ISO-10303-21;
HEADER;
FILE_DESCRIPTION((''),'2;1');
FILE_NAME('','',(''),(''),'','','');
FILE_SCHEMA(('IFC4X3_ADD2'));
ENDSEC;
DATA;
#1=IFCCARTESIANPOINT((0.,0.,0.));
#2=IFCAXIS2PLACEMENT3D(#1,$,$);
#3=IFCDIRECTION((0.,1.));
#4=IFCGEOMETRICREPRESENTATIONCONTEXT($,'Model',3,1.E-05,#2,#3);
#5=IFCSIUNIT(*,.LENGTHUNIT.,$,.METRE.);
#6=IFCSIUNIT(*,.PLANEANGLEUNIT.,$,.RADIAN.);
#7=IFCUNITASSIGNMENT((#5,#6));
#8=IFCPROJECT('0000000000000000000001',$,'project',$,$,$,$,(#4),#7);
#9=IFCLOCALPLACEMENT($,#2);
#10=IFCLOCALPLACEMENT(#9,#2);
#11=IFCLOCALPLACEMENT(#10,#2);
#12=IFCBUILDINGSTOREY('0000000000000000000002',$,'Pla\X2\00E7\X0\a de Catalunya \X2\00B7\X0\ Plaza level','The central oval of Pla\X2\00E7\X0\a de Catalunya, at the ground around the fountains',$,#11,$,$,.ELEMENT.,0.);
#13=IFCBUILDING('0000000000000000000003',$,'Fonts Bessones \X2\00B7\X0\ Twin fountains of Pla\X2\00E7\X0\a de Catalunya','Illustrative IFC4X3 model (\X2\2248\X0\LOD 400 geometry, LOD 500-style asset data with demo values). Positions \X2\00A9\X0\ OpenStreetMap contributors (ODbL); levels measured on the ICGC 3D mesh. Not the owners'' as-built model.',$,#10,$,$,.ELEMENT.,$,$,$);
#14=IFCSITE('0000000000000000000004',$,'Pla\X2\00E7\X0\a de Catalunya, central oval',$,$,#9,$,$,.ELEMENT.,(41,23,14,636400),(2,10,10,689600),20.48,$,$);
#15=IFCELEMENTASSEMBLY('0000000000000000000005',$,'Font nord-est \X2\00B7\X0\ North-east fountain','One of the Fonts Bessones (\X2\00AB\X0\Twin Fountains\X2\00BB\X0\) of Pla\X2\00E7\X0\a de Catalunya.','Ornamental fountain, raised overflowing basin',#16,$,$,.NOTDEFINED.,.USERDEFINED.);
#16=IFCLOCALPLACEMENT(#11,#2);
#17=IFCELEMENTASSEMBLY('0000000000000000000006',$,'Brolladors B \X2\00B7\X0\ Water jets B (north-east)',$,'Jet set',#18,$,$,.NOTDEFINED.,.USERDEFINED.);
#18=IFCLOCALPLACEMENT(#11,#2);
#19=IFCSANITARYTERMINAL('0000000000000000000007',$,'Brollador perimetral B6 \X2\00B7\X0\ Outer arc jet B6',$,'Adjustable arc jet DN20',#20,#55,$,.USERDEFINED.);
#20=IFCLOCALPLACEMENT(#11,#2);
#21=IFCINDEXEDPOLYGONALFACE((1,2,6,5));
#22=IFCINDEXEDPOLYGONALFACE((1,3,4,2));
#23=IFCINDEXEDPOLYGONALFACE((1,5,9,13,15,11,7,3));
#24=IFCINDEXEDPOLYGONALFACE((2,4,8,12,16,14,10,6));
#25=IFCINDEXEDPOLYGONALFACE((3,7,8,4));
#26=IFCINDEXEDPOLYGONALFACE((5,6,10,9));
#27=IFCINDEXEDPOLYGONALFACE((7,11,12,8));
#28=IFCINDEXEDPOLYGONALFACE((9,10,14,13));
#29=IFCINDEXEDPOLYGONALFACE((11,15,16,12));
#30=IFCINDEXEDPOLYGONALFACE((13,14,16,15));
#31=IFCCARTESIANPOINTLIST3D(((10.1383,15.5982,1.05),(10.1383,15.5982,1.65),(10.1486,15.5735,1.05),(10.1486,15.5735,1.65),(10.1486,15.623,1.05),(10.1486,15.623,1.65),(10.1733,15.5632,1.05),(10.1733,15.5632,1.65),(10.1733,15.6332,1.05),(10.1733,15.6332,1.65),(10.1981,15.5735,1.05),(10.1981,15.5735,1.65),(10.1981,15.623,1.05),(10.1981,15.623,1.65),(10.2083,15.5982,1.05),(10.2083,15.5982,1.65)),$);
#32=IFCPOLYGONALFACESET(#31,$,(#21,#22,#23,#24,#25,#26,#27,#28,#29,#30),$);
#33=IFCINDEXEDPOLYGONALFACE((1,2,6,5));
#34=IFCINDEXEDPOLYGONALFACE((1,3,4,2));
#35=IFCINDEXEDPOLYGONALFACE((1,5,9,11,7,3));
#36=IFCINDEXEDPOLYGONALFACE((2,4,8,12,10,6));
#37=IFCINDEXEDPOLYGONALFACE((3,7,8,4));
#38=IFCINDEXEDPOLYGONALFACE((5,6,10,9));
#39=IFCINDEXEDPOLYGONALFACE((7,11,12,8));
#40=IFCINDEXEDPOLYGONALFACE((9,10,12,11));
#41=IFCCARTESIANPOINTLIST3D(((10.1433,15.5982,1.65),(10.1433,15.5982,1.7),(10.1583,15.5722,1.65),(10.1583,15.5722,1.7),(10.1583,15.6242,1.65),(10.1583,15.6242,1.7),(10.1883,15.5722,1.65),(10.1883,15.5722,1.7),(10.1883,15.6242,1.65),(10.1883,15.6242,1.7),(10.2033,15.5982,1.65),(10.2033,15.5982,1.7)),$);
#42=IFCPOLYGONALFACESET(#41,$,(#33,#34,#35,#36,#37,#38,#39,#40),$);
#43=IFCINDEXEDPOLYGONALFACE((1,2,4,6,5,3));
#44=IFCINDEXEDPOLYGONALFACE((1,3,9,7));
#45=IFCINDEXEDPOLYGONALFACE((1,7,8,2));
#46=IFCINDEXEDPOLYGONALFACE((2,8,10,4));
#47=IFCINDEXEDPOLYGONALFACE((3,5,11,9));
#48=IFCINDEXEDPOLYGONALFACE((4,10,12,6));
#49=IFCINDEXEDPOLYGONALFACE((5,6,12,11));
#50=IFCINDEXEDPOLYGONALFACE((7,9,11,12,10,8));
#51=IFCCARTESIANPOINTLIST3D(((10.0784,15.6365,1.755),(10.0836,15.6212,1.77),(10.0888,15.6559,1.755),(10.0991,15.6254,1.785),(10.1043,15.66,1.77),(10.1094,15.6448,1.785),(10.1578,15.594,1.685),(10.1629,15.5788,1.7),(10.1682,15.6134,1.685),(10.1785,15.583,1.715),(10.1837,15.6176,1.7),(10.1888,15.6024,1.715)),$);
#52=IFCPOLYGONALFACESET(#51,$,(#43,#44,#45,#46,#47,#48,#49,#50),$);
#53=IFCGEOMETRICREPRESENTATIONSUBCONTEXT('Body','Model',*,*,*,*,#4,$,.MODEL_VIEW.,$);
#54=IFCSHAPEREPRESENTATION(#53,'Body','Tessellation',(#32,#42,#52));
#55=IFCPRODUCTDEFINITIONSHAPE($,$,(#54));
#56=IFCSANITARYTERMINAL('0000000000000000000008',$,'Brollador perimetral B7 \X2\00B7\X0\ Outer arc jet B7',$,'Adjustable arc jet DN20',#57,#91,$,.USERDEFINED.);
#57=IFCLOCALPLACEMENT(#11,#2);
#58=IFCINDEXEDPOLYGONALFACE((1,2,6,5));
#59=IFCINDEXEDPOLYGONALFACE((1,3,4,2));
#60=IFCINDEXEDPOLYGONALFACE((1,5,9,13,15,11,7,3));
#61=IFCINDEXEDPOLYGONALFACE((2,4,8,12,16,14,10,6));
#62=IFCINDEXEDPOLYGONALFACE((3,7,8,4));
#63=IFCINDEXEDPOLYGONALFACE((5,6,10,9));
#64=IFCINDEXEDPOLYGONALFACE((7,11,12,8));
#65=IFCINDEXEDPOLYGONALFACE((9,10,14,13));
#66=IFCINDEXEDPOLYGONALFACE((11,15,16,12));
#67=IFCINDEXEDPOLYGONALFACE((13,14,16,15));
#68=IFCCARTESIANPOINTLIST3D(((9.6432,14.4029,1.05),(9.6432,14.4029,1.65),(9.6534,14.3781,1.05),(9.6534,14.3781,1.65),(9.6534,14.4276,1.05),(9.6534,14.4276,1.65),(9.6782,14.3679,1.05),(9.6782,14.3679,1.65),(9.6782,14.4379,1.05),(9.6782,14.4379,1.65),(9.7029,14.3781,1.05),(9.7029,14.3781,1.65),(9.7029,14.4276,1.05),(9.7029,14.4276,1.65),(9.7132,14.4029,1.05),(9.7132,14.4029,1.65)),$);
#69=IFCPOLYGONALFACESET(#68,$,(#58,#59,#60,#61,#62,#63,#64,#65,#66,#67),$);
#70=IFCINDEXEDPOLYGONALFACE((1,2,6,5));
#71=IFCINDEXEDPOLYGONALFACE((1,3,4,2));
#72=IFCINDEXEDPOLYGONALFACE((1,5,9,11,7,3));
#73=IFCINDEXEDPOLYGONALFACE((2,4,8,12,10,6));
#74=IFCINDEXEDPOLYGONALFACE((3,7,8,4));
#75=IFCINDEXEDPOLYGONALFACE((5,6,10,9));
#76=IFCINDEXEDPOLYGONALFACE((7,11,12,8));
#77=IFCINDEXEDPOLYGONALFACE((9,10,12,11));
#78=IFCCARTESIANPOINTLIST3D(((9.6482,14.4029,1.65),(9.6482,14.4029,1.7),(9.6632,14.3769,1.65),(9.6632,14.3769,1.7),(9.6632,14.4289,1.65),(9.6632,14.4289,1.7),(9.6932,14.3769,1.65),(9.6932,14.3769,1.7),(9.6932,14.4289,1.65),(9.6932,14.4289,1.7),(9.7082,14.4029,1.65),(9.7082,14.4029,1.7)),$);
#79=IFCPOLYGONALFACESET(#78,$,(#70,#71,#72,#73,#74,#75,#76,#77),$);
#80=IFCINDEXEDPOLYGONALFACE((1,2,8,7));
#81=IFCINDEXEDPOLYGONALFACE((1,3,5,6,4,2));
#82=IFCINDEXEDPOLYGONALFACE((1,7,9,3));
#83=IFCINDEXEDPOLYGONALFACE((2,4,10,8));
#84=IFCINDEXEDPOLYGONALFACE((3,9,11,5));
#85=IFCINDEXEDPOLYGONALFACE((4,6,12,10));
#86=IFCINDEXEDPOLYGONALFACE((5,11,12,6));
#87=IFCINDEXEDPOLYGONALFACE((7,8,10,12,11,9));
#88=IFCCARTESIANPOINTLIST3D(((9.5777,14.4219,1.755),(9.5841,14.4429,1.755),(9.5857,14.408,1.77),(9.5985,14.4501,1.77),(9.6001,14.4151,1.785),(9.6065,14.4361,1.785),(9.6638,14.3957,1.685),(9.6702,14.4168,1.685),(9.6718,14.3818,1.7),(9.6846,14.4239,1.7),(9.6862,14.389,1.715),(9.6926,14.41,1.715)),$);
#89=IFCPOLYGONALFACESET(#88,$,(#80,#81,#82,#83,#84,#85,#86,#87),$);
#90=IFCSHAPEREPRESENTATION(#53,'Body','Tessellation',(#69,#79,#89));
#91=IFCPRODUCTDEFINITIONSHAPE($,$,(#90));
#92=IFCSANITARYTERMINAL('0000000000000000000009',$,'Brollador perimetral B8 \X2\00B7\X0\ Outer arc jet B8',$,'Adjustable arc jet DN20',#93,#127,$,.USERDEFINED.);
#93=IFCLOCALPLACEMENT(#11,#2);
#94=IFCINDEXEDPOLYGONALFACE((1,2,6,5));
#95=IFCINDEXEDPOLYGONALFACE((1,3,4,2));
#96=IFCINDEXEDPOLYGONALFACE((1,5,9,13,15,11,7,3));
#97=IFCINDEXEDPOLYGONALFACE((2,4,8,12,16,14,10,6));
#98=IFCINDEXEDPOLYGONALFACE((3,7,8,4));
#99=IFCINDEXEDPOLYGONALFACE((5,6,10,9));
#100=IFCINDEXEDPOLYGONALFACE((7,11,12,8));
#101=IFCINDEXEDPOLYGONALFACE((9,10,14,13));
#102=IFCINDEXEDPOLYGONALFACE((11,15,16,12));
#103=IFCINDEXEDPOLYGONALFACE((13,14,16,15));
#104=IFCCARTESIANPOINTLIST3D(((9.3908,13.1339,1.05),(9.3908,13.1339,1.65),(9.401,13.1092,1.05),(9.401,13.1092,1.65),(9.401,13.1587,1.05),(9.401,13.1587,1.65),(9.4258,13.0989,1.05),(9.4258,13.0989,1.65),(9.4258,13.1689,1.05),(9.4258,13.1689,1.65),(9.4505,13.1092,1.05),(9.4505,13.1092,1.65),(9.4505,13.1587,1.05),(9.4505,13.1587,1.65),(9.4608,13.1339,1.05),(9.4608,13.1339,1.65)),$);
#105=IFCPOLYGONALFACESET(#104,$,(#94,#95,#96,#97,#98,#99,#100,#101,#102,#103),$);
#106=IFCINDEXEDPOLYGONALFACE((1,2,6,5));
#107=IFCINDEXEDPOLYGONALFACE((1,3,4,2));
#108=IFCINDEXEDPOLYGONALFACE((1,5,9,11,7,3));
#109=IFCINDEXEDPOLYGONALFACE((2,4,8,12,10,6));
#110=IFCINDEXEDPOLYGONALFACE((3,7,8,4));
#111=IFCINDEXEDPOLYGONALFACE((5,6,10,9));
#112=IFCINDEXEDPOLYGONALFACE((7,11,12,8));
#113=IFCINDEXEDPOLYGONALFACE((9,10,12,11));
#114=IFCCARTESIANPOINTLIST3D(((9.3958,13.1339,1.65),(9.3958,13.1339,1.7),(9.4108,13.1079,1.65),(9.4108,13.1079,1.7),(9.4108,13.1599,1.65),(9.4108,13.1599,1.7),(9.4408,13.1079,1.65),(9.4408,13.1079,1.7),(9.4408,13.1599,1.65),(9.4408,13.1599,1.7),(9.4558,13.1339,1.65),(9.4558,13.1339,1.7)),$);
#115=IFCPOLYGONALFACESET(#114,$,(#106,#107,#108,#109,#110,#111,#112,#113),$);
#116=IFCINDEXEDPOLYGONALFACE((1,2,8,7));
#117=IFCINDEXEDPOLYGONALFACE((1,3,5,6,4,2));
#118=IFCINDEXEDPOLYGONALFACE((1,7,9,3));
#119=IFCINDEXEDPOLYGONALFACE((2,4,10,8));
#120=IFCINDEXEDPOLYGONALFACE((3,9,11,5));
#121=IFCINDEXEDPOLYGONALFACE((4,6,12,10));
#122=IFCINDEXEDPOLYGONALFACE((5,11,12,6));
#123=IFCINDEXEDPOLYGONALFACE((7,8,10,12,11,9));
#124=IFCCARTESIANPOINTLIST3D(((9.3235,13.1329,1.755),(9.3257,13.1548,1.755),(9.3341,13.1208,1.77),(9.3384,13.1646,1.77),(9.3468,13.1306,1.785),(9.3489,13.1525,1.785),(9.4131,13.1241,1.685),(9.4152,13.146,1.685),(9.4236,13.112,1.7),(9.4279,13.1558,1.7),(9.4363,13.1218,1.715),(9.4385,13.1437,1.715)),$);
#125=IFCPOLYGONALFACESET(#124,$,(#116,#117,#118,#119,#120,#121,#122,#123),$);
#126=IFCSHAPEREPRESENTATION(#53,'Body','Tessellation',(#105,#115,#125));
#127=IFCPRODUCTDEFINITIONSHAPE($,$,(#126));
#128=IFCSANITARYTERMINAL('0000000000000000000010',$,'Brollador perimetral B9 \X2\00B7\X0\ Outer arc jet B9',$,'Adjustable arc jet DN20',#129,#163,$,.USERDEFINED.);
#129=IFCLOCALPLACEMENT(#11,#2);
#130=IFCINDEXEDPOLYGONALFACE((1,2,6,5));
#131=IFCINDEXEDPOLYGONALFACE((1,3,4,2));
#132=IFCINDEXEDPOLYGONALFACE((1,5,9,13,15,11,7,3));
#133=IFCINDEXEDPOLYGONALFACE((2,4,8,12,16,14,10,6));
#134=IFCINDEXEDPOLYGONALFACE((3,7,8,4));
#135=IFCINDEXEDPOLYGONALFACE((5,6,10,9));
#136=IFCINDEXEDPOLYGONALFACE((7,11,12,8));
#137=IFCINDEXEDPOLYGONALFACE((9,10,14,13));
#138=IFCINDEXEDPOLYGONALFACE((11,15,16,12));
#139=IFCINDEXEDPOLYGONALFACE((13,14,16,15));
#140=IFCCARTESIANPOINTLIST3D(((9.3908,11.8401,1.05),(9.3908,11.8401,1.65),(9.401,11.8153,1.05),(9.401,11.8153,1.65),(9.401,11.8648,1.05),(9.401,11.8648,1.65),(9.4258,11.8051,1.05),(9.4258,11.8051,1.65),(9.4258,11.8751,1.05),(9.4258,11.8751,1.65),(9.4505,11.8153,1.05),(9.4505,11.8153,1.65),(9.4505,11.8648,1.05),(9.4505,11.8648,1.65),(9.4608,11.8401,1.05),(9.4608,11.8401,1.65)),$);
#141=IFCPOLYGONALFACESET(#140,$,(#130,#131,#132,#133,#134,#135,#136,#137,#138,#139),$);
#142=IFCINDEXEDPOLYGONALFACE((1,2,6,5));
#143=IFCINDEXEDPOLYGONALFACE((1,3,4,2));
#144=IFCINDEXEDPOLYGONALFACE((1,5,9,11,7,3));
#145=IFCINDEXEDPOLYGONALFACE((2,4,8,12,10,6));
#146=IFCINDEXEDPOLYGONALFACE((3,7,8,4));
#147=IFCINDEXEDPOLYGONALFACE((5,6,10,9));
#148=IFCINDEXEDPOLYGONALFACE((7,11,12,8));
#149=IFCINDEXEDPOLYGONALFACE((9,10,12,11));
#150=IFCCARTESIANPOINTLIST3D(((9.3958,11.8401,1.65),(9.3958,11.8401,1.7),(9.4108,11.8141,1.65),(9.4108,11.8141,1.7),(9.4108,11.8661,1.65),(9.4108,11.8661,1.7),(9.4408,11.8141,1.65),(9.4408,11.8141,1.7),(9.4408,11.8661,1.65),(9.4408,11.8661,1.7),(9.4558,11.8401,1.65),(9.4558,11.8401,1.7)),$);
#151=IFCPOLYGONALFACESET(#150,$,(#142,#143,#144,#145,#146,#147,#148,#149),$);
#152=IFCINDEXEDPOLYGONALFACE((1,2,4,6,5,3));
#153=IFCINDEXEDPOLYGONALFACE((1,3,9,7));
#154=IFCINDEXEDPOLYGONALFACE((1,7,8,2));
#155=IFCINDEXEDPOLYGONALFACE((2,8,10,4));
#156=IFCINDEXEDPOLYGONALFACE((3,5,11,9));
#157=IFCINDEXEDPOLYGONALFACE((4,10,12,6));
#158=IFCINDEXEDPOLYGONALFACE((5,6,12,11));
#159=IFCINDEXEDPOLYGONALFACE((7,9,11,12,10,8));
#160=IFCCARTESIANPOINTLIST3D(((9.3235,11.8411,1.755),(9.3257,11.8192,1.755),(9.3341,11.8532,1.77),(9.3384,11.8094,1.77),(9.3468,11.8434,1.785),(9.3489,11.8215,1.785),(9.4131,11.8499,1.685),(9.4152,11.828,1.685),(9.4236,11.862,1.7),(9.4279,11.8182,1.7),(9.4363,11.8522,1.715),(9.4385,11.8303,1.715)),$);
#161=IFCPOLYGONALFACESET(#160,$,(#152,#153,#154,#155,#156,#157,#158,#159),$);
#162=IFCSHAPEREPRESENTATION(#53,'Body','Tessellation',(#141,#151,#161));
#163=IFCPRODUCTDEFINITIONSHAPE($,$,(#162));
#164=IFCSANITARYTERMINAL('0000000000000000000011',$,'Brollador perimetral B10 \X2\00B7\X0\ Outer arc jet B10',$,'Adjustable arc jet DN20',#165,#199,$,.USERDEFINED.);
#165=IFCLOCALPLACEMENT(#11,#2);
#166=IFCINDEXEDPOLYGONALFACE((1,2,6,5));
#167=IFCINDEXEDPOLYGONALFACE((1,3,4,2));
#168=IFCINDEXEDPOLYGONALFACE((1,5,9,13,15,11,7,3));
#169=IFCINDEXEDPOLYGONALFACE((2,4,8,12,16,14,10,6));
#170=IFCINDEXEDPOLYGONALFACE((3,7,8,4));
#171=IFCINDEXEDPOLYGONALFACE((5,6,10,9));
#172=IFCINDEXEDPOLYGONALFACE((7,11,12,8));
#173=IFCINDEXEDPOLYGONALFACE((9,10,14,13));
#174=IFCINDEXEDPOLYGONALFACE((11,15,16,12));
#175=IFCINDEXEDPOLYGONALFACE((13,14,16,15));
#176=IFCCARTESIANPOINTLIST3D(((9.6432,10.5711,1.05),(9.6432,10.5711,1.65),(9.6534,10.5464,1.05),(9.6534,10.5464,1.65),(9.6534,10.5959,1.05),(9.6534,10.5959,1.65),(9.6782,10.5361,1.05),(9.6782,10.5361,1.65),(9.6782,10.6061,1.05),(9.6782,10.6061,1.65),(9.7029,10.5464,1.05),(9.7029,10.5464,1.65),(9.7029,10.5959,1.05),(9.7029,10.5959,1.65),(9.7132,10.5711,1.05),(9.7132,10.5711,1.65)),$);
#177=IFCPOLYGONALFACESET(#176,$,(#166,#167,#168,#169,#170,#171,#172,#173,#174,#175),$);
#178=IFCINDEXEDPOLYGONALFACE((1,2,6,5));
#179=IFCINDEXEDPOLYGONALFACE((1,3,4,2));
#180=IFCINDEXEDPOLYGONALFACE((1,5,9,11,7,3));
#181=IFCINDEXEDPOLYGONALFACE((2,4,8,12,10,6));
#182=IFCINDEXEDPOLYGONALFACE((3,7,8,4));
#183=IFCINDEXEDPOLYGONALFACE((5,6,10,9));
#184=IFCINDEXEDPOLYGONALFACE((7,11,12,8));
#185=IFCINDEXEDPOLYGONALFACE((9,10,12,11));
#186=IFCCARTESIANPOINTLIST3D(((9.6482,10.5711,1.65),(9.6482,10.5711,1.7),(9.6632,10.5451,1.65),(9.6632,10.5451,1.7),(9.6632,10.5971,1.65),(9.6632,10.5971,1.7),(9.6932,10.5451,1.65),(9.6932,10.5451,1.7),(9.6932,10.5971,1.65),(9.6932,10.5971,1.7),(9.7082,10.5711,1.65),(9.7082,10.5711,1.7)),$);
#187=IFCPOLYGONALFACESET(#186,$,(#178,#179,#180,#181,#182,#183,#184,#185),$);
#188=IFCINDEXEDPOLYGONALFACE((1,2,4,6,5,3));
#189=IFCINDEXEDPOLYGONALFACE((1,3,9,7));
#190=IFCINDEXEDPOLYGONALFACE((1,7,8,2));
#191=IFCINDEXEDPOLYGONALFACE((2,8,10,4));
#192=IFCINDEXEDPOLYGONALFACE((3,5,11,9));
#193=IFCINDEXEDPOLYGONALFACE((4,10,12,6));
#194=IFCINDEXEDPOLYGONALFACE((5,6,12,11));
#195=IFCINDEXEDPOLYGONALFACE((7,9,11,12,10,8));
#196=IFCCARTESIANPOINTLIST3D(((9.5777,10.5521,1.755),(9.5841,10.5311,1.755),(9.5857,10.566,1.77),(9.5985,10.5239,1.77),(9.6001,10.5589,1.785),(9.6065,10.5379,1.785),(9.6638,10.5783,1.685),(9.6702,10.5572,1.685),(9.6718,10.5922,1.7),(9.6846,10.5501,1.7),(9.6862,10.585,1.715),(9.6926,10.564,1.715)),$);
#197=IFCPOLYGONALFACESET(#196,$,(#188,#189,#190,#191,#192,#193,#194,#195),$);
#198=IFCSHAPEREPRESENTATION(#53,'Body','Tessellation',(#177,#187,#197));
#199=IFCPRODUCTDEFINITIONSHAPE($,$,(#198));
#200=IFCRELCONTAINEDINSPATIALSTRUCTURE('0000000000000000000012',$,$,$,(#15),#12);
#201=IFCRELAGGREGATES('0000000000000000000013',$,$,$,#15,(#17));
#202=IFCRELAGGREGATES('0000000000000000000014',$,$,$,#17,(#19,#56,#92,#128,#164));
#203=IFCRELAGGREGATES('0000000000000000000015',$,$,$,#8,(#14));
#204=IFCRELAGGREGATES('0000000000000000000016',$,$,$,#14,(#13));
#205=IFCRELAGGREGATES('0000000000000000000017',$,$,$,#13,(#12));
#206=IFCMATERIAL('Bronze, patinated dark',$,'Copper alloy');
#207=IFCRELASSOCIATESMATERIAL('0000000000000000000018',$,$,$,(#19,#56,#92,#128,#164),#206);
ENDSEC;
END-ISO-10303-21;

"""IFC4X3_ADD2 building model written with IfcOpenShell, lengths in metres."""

from ifc_helpers import new_model, si_unit, direction, frame, origin, place, context, subcontext, project, spatial, polyline, outline, extrude, material, element, aggregate, save


model = new_model("IFC4X3_ADD2")

# Units and contexts
model_context = context("Model", 3, precision=1e-05, world=origin(), true_north=direction((0.0, 1.0)))
body_context = subcontext(model_context, "Body", "Model", "MODEL_VIEW")
ifc_project = project(units=[si_unit("LENGTHUNIT", "METRE"), si_unit("PLANEANGLEUNIT", "RADIAN")], contexts=[model_context])

# Site, building, storey
site_placement = place(None, origin())
site = spatial("IfcSite", under=ifc_project, at=site_placement, Name="Plaça de Catalunya, central oval", CompositionType="ELEMENT", RefLatitude=(41, 23, 14, 636400), RefLongitude=(2, 10, 10, 689600), RefElevation=20.48)
building_placement = place(site_placement, origin())
building = spatial("IfcBuilding", under=site, at=building_placement, Name="Fonts Bessones · Twin fountains of Plaça de Catalunya", Description="Illustrative IFC4X3 model (≈LOD 400 geometry, LOD 500-style asset data with demo values). Positions © OpenStreetMap contributors (ODbL); levels measured on the ICGC 3D mesh. Not the owners' as-built model.", CompositionType="ELEMENT")
storey_placement = place(building_placement, origin())
storey = spatial("IfcBuildingStorey", under=building, at=storey_placement, Name="Plaça de Catalunya · Plaza level", Description="The central oval of Plaça de Catalunya, at the ground around the fountains", CompositionType="ELEMENT", Elevation=0.0)

# Element assemblies, sanitary terminals
assembly_1_placement = place(building_placement, origin())
assembly_1 = element("IfcElementAssembly", 1, at=assembly_1_placement, inside=storey, Name="Font nord-est · North-east fountain", Description="One of the Fonts Bessones («Twin Fountains») of Plaça de Catalunya.", ObjectType="Ornamental fountain, raised overflowing basin", AssemblyPlace="NOTDEFINED", PredefinedType="USERDEFINED")
assembly_2_placement = place(building_placement, origin())
assembly_2 = element("IfcElementAssembly", 2, at=assembly_2_placement, Name="Brolladors B · Water jets B (north-east)", ObjectType="Jet set", AssemblyPlace="NOTDEFINED", PredefinedType="USERDEFINED")
aggregate(assembly_1, [assembly_2])
ifc_material_1 = material(Name="Bronze, patinated dark", Category="Copper alloy")
sanitary_terminal_1_placement = place(building_placement, origin())
sanitary_terminal_1 = element("IfcSanitaryTerminal", 3, at=sanitary_terminal_1_placement, material=ifc_material_1, Name="Brollador perimetral B6 · Outer arc jet B6", ObjectType="Adjustable arc jet DN20", PredefinedType="USERDEFINED", context=body_context, shape_type="SweptSolid", body=[
    extrude(outline(polyline([(10.2083, 15.5982), (10.1981, 15.623), (10.1733, 15.6332), (10.1486, 15.623), (10.1383, 15.5982), (10.1486, 15.5735), (10.1733, 15.5632), (10.1981, 15.5735), (10.2083, 15.5982)])), frame((0.0, 0.0, 1.05)), (0.0, 0.0, 1.0), 0.6),
    extrude(outline(polyline([(10.2033, 15.5982), (10.1883, 15.6242), (10.1583, 15.6242), (10.1433, 15.5982), (10.1583, 15.5722), (10.1883, 15.5722), (10.2033, 15.5982)])), frame((0.0, 0.0, 1.65)), (0.0, 0.0, 1.0), 0.05),
    extrude(outline(polyline([(0.022, 0.0), (0.011, 0.0191), (-0.011, 0.0191), (-0.022, 0.0), (-0.011, -0.0191), (0.011, -0.0191), (0.022, 0.0)])), frame((10.1733, 15.5982, 1.7), z_axis=(-0.696147, 0.372098, 0.613941), x_axis=(0.471397, 0.881921, 0.0)), (0.0, 0.0, 1.0), 0.114),
])
sanitary_terminal_2_placement = place(building_placement, origin())
sanitary_terminal_2 = element("IfcSanitaryTerminal", 4, at=sanitary_terminal_2_placement, material=ifc_material_1, Name="Brollador perimetral B7 · Outer arc jet B7", ObjectType="Adjustable arc jet DN20", PredefinedType="USERDEFINED", context=body_context, shape_type="SweptSolid", body=[
    extrude(outline(polyline([(9.7132, 14.4029), (9.7029, 14.4276), (9.6782, 14.4379), (9.6534, 14.4276), (9.6432, 14.4029), (9.6534, 14.3781), (9.6782, 14.3679), (9.7029, 14.3781), (9.7132, 14.4029)])), frame((0.0, 0.0, 1.05)), (0.0, 0.0, 1.0), 0.6),
    extrude(outline(polyline([(9.7082, 14.4029), (9.6932, 14.4289), (9.6632, 14.4289), (9.6482, 14.4029), (9.6632, 14.3769), (9.6932, 14.3769), (9.7082, 14.4029)])), frame((0.0, 0.0, 1.65)), (0.0, 0.0, 1.0), 0.05),
    extrude(outline(polyline([(0.022, 0.0), (0.011, 0.0191), (-0.011, 0.0191), (-0.022, 0.0), (-0.011, -0.0191), (0.011, -0.0191), (0.022, 0.0)])), frame((9.6782, 14.4029, 1.7), z_axis=(-0.755363, 0.229137, 0.613941), x_axis=(0.290285, 0.95694, 0.0)), (0.0, 0.0, 1.0), 0.114),
])
sanitary_terminal_3_placement = place(building_placement, origin())
sanitary_terminal_3 = element("IfcSanitaryTerminal", 5, at=sanitary_terminal_3_placement, material=ifc_material_1, Name="Brollador perimetral B8 · Outer arc jet B8", ObjectType="Adjustable arc jet DN20", PredefinedType="USERDEFINED", context=body_context, shape_type="SweptSolid", body=[
    extrude(outline(polyline([(9.4608, 13.1339), (9.4505, 13.1587), (9.4258, 13.1689), (9.401, 13.1587), (9.3908, 13.1339), (9.401, 13.1092), (9.4258, 13.0989), (9.4505, 13.1092), (9.4608, 13.1339)])), frame((0.0, 0.0, 1.05)), (0.0, 0.0, 1.0), 0.6),
    extrude(outline(polyline([(9.4558, 13.1339), (9.4408, 13.1599), (9.4108, 13.1599), (9.3958, 13.1339), (9.4108, 13.1079), (9.4408, 13.1079), (9.4558, 13.1339)])), frame((0.0, 0.0, 1.65)), (0.0, 0.0, 1.0), 0.05),
    extrude(outline(polyline([(0.022, 0.0), (0.011, 0.0191), (-0.011, 0.0191), (-0.022, 0.0), (-0.011, -0.0191), (0.011, -0.0191), (0.022, 0.0)])), frame((9.4258, 13.1339, 1.7), z_axis=(-0.785551, 0.07737, 0.613941), x_axis=(0.098017, 0.995185, 0.0)), (0.0, 0.0, 1.0), 0.114),
])
sanitary_terminal_4_placement = place(building_placement, origin())
sanitary_terminal_4 = element("IfcSanitaryTerminal", 6, at=sanitary_terminal_4_placement, material=ifc_material_1, Name="Brollador perimetral B9 · Outer arc jet B9", ObjectType="Adjustable arc jet DN20", PredefinedType="USERDEFINED", context=body_context, shape_type="SweptSolid", body=[
    extrude(outline(polyline([(9.4608, 11.8401), (9.4505, 11.8648), (9.4258, 11.8751), (9.401, 11.8648), (9.3908, 11.8401), (9.401, 11.8153), (9.4258, 11.8051), (9.4505, 11.8153), (9.4608, 11.8401)])), frame((0.0, 0.0, 1.05)), (0.0, 0.0, 1.0), 0.6),
    extrude(outline(polyline([(9.4558, 11.8401), (9.4408, 11.8661), (9.4108, 11.8661), (9.3958, 11.8401), (9.4108, 11.8141), (9.4408, 11.8141), (9.4558, 11.8401)])), frame((0.0, 0.0, 1.65)), (0.0, 0.0, 1.0), 0.05),
    extrude(outline(polyline([(0.022, 0.0), (0.011, 0.0191), (-0.011, 0.0191), (-0.022, 0.0), (-0.011, -0.0191), (0.011, -0.0191), (0.022, 0.0)])), frame((9.4258, 11.8401, 1.7), z_axis=(-0.785551, -0.07737, 0.613941), x_axis=(-0.098017, 0.995185, 0.0)), (0.0, 0.0, 1.0), 0.114),
])
sanitary_terminal_5_placement = place(building_placement, origin())
sanitary_terminal_5 = element("IfcSanitaryTerminal", 7, at=sanitary_terminal_5_placement, material=ifc_material_1, Name="Brollador perimetral B10 · Outer arc jet B10", ObjectType="Adjustable arc jet DN20", PredefinedType="USERDEFINED", context=body_context, shape_type="SweptSolid", body=[
    extrude(outline(polyline([(9.7132, 10.5711), (9.7029, 10.5959), (9.6782, 10.6061), (9.6534, 10.5959), (9.6432, 10.5711), (9.6534, 10.5464), (9.6782, 10.5361), (9.7029, 10.5464), (9.7132, 10.5711)])), frame((0.0, 0.0, 1.05)), (0.0, 0.0, 1.0), 0.6),
    extrude(outline(polyline([(9.7082, 10.5711), (9.6932, 10.5971), (9.6632, 10.5971), (9.6482, 10.5711), (9.6632, 10.5451), (9.6932, 10.5451), (9.7082, 10.5711)])), frame((0.0, 0.0, 1.65)), (0.0, 0.0, 1.0), 0.05),
    extrude(outline(polyline([(0.022, 0.0), (0.011, 0.0191), (-0.011, 0.0191), (-0.022, 0.0), (-0.011, -0.0191), (0.011, -0.0191), (0.022, 0.0)])), frame((9.6782, 10.5711, 1.7), z_axis=(-0.755363, -0.229137, 0.613941), x_axis=(-0.290285, 0.95694, 0.0)), (0.0, 0.0, 1.0), 0.114),
])
aggregate(assembly_2, [sanitary_terminal_1, sanitary_terminal_2, sanitary_terminal_3, sanitary_terminal_4, sanitary_terminal_5])

save(model, "model.ifc")
